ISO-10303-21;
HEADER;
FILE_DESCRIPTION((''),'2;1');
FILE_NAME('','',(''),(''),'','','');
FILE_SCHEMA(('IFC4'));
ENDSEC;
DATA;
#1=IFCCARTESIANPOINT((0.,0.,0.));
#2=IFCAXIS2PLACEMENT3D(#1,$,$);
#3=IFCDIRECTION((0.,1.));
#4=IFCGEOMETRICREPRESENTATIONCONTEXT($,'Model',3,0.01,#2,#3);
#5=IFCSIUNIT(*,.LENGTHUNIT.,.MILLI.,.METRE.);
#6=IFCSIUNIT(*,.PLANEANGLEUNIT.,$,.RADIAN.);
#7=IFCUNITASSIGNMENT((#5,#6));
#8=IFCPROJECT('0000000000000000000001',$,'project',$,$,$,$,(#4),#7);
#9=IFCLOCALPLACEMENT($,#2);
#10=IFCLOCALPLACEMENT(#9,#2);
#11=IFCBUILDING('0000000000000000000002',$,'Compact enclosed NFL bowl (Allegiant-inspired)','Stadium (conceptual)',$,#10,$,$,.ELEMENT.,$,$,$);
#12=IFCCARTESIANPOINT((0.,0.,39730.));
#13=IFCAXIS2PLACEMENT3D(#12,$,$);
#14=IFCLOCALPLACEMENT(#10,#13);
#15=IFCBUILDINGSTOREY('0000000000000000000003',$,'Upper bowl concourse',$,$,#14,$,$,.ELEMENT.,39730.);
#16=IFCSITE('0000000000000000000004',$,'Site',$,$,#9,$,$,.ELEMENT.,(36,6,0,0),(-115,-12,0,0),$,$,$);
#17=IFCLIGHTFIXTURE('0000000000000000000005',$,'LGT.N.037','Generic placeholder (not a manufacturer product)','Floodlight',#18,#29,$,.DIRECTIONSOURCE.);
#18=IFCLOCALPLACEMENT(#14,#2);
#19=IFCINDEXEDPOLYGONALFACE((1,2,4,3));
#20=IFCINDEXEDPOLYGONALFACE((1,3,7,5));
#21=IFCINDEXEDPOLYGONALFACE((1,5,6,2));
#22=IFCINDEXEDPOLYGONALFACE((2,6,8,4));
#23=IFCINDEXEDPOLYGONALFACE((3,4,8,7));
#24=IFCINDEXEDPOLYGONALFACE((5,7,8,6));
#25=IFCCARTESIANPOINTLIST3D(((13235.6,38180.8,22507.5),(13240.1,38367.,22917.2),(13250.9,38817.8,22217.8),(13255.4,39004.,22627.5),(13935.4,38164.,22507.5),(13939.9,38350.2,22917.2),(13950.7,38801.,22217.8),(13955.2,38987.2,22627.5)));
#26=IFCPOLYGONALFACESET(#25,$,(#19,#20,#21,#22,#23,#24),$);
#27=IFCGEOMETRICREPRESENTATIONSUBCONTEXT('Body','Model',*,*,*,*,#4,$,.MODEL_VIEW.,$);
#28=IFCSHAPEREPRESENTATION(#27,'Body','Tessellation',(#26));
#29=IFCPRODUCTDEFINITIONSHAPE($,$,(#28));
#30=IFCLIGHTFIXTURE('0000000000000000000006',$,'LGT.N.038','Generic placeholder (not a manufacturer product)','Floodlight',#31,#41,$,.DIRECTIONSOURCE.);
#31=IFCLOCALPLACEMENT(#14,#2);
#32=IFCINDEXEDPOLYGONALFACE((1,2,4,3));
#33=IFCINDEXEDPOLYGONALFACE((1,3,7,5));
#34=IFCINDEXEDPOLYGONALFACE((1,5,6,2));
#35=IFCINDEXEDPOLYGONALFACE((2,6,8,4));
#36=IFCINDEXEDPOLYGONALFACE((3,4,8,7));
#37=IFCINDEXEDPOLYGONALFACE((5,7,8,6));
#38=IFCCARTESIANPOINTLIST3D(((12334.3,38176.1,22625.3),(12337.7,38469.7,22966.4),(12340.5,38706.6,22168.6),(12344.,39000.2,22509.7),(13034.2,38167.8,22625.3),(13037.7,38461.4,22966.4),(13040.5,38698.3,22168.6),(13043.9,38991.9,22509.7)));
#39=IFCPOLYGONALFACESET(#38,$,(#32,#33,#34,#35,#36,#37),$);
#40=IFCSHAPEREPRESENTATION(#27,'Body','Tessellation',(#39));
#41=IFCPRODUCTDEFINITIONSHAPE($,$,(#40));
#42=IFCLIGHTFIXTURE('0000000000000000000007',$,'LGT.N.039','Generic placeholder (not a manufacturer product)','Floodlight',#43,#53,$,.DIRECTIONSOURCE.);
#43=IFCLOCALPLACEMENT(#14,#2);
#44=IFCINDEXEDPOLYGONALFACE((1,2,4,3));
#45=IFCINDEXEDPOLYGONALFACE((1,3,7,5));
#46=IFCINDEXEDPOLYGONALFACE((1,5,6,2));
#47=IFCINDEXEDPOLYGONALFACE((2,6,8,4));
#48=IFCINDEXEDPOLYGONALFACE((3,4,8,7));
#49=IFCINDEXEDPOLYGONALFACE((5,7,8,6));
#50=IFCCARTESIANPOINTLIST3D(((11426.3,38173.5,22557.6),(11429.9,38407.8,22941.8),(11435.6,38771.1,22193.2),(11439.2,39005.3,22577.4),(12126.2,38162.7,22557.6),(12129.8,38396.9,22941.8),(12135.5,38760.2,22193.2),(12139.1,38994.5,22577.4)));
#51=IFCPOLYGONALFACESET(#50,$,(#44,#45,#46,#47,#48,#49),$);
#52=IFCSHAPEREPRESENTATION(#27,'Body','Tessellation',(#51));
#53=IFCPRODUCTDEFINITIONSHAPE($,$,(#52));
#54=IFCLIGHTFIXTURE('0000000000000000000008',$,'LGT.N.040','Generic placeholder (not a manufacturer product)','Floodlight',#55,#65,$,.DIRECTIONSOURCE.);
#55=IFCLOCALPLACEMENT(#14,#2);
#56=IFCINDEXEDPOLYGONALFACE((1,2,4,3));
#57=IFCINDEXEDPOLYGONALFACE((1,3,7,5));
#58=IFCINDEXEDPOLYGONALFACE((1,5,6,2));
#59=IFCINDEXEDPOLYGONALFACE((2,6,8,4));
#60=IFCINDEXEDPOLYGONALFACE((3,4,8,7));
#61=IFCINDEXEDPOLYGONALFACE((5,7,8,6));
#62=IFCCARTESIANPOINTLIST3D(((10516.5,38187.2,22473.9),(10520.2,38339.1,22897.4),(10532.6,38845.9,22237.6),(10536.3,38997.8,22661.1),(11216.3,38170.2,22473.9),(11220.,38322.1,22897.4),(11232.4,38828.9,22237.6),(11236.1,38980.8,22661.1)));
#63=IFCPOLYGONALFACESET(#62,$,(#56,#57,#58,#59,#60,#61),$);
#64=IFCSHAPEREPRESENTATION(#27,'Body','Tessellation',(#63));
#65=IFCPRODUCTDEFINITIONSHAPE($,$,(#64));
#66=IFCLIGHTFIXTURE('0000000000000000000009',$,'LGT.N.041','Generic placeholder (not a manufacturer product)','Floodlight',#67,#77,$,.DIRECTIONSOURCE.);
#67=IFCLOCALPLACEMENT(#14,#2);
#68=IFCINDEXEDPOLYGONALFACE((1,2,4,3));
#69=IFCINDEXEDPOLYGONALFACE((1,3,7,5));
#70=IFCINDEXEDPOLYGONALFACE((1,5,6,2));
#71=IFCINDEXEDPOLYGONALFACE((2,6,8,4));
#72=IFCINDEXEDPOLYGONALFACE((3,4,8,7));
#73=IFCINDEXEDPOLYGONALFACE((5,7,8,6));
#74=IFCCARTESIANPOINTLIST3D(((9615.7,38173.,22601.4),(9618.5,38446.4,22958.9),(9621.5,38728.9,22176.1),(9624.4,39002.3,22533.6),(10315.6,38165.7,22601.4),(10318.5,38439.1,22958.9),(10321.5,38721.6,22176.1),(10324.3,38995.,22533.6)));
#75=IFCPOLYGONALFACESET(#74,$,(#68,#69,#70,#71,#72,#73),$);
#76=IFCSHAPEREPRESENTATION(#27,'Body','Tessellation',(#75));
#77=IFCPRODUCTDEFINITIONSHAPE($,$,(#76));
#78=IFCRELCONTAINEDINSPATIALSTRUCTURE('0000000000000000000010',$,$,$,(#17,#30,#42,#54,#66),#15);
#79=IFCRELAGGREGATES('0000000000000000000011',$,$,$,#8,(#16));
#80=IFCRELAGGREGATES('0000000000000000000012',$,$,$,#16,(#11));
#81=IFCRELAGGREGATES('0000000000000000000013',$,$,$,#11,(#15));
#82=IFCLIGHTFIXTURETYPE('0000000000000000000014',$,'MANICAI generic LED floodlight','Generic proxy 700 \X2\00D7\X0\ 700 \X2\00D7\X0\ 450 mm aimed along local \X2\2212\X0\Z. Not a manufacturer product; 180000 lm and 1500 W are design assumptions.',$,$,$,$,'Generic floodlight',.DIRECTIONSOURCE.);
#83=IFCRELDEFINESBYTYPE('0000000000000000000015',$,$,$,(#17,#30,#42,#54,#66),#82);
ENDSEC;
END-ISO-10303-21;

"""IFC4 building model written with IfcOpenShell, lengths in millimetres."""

from ifc_helpers import new_model, si_unit, direction, frame, origin, place, context, subcontext, project, spatial, rectangle, extrude, source, transform, mapped, type_object, type_shapes, element, save


model = new_model("IFC4")

# Units and contexts
model_context = context("Model", 3, precision=0.01, world=origin(), true_north=direction((0.0, 1.0)))
body_context = subcontext(model_context, "Body", "Model", "MODEL_VIEW")
ifc_project = project(units=[si_unit("LENGTHUNIT", "METRE", prefix="MILLI"), si_unit("PLANEANGLEUNIT", "RADIAN")], contexts=[model_context])

# Site, building, storey
site_placement = place(None, origin())
site = spatial("IfcSite", under=ifc_project, at=site_placement, Name="Site", CompositionType="ELEMENT", RefLatitude=(36, 6, 0, 0), RefLongitude=(-115, -12, 0, 0))
building_placement = place(site_placement, origin())
building = spatial("IfcBuilding", under=site, at=building_placement, Name="Compact enclosed NFL bowl (Allegiant-inspired)", Description="Stadium (conceptual)", CompositionType="ELEMENT")
storey_placement = place(building_placement, frame((0.0, 0.0, 39730.0)))
storey = spatial("IfcBuildingStorey", under=building, at=storey_placement, Name="Upper bowl concourse", CompositionType="ELEMENT", Elevation=39730.0)

# Light fixtures
light_fixture_type = type_object("IfcLightFixtureType", Name="MANICAI generic LED floodlight", Description="Generic proxy 700 × 700 × 450 mm aimed along local −Z. Not a manufacturer product; 180000 lm and 1500 W are design assumptions.", ElementType="Generic floodlight", PredefinedType="DIRECTIONSOURCE")
shared_shape = source(origin(), body_context, "Body", "SweptSolid", [
    extrude(rectangle(XDim=700.0, YDim=700.0), frame((0.0, 0.0, -225.0)), (0.0, 0.0, 1.0), 450.0),
])
type_shapes(light_fixture_type, [shared_shape])
for number, where, z_axis, x_axis, name in (
    (1, (13595.4, 38584.0, 22567.5), (0.009934, 0.413708, 0.910355), (-0.999712, 0.024004, 0.0), "LGT.N.037"),
    (2, (12689.1, 38584.0, 22567.5), (0.007718, 0.65239, 0.757844), (-0.99993, 0.01183, 0.0), "LGT.N.038"),
    (3, (11782.7, 38584.0, 22567.5), (0.008074, 0.520542, 0.853798), (-0.99988, 0.015509, 0.0), "LGT.N.039"),
    (4, (10876.3, 38584.0, 22567.5), (0.008217, 0.337465, 0.941302), (-0.999704, 0.024342, 0.0), "LGT.N.040"),
    (5, (9970.0, 38584.0, 22567.5), (0.006356, 0.607541, 0.794263), (-0.999945, 0.010461, 0.0), "LGT.N.041"),
):
    element("IfcLightFixture", number, at=place(storey_placement, frame(where, z_axis=z_axis, x_axis=x_axis)), inside=storey, type_object=light_fixture_type, Name=name, Description="Generic placeholder (not a manufacturer product)", ObjectType="Floodlight", PredefinedType="DIRECTIONSOURCE", context=body_context, shape_type="MappedRepresentation", body=[
        mapped(shared_shape, transform((0.0, 0.0, 0.0))),
    ])

save(model, "model.ifc")
